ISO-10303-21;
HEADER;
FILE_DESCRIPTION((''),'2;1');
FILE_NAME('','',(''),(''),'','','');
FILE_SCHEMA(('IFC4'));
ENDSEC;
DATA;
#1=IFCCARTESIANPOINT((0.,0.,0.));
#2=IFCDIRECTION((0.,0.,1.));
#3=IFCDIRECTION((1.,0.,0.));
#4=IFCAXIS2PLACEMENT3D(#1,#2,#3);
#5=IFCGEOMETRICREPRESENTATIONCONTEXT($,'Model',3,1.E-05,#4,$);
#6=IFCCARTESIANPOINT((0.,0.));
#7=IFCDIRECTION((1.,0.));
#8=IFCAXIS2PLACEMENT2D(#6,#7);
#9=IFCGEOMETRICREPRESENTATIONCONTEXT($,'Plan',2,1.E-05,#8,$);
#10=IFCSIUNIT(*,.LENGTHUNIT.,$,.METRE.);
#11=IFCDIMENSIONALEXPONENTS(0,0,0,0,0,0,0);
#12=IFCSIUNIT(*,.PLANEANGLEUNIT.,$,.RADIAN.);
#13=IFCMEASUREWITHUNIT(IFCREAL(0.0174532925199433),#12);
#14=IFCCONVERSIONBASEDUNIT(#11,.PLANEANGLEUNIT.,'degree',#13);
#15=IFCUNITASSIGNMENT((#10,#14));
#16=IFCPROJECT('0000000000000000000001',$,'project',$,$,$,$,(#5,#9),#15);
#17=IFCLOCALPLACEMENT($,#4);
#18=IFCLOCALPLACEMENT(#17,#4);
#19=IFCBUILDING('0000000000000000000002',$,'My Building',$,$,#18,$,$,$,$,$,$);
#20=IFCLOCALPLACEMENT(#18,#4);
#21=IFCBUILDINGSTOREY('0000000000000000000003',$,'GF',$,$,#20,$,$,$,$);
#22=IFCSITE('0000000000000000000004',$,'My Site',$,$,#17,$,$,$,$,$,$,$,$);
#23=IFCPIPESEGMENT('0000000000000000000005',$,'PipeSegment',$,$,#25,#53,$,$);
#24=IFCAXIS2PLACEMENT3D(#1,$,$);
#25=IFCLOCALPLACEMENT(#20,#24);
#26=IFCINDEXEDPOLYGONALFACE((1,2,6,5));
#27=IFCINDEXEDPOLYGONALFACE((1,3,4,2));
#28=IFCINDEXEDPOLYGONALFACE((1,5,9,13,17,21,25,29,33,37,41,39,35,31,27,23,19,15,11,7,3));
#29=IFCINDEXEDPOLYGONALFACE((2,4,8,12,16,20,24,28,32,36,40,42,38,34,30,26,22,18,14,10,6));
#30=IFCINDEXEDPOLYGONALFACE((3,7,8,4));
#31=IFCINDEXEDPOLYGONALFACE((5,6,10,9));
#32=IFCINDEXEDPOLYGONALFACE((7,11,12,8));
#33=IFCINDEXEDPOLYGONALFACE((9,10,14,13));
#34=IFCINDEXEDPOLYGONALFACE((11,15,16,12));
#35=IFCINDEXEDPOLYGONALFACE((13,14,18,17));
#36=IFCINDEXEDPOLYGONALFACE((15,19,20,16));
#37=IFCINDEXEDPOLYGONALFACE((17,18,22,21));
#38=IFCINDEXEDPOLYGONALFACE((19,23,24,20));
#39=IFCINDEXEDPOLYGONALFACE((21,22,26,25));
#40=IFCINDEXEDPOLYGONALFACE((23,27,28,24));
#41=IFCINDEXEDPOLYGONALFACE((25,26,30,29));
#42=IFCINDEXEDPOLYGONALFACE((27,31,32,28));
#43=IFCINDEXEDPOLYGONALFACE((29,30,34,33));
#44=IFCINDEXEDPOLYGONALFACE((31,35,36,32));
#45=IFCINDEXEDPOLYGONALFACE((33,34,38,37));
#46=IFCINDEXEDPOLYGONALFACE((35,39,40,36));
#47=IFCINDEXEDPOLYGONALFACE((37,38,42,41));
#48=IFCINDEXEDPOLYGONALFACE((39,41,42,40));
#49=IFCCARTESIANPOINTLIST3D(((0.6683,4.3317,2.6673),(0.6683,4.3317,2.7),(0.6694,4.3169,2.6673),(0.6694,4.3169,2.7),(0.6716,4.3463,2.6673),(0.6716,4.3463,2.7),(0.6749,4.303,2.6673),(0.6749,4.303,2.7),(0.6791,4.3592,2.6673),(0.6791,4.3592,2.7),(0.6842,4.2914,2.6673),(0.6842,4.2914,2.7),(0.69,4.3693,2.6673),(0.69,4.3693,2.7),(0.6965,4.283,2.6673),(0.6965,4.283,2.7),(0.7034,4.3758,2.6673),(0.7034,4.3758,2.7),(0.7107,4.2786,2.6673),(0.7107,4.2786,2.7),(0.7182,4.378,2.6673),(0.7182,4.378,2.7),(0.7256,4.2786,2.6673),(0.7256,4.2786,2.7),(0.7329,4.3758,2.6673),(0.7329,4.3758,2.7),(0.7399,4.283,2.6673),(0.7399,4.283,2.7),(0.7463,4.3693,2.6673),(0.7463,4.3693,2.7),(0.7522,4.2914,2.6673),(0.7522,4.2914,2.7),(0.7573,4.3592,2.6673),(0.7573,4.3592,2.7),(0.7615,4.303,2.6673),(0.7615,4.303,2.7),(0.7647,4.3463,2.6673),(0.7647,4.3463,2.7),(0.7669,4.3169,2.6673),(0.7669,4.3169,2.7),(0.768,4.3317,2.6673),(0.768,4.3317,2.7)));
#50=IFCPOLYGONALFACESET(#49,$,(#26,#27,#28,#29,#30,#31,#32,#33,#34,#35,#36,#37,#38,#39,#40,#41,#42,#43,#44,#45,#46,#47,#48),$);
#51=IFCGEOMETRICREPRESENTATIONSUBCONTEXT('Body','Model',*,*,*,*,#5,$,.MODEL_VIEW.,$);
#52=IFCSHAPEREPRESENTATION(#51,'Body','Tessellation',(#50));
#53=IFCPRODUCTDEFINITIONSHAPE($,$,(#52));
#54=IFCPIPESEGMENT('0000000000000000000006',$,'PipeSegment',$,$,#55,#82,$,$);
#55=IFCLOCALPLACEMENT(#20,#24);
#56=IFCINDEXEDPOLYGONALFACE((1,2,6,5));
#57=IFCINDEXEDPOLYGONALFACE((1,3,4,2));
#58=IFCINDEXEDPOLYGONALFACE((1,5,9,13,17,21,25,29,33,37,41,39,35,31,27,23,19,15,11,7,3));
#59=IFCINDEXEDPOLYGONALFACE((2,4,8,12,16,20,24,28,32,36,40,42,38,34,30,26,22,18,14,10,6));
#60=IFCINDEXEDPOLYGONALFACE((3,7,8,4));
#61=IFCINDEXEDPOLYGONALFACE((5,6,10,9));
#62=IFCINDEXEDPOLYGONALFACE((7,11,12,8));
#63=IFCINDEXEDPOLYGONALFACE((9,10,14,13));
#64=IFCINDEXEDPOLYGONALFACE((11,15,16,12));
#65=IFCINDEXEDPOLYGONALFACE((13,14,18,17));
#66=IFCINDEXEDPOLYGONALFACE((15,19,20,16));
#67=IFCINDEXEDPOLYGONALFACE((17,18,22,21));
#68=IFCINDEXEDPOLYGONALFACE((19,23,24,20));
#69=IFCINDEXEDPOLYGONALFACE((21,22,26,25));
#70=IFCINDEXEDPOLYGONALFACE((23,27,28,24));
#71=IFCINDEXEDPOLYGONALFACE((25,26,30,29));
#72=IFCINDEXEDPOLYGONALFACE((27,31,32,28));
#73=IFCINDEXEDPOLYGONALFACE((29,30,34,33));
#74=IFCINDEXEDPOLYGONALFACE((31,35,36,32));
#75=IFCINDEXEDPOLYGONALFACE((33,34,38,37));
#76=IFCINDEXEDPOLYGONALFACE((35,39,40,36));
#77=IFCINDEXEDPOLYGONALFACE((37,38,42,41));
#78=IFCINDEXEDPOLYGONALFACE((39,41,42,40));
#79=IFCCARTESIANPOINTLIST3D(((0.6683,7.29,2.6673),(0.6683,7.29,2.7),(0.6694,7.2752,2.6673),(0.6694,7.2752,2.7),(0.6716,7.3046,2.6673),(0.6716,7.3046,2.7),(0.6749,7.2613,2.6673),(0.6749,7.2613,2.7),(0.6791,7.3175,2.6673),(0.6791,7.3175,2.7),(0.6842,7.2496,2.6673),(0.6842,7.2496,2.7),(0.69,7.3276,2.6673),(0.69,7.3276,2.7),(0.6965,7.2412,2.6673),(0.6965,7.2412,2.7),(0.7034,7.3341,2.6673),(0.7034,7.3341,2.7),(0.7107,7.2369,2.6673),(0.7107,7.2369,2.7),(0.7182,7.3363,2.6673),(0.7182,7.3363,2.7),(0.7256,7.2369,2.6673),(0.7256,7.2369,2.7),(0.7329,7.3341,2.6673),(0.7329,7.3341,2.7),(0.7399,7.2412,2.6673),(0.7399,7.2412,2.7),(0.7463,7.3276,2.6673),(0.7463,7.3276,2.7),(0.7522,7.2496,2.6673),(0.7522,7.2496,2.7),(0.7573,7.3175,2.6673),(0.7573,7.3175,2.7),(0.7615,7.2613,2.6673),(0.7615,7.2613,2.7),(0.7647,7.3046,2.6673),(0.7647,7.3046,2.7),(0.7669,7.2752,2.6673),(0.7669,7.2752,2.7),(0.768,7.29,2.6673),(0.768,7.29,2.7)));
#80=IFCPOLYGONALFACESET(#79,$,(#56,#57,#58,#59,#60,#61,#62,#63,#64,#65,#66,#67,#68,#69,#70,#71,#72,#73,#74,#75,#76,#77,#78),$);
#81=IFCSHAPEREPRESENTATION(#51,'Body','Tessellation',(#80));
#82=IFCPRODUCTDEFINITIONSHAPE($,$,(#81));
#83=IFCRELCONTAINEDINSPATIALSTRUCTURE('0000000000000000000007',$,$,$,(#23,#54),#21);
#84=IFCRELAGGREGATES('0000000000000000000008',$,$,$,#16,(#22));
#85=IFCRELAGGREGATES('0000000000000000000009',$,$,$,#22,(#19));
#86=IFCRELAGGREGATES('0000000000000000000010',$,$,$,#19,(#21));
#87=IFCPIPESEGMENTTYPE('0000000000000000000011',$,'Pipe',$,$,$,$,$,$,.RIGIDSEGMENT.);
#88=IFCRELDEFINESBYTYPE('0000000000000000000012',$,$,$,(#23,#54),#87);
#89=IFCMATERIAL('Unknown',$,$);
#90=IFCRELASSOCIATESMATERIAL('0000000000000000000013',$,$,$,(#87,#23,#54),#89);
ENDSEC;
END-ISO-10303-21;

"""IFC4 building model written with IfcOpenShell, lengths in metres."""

from ifc_helpers import new_model, entity, si_unit, converted_unit, frame, origin_with_axes, origin_2d_with_axis, place, context, subcontext, project, spatial, circle, extrude, material, material_profile, profile_set, profile_usage, type_object, element, save


model = new_model("IFC4")

# Units and contexts
model_context = context("Model", 3, precision=1e-05, world=origin_with_axes())
plan_context = context("Plan", 2, precision=1e-05, world=origin_2d_with_axis())
body_context_1 = subcontext(model_context, "Body", "Model", "MODEL_VIEW")
ifc_project = project(units=[si_unit("LENGTHUNIT", "METRE"), converted_unit("PLANEANGLEUNIT", "degree", entity("IfcReal", 0.0174532925199433), si_unit("PLANEANGLEUNIT", "RADIAN"), dimensions=[0, 0, 0, 0, 0, 0, 0])], contexts=[model_context, plan_context])

# Site, building, storey
site_placement = place(None, origin_with_axes())
site = spatial("IfcSite", under=ifc_project, at=site_placement, Name="My Site")
building_placement = place(site_placement, origin_with_axes())
building = spatial("IfcBuilding", under=site, at=building_placement, Name="My Building")
storey_placement = place(building_placement, origin_with_axes())
storey = spatial("IfcBuildingStorey", under=building, at=storey_placement, Name="GF")

# Shared definitions
ifc_material = material(Name="Unknown")

# Pipe segments
ifc_material_profile = material_profile(ifc_material, circle(Radius=0.05))
ifc_profile_set = profile_set([ifc_material_profile])
pipe_segment_type = type_object("IfcPipeSegmentType", Name="Pipe", PredefinedType="RIGIDSEGMENT", material=ifc_profile_set)
ifc_profile_usage_1 = profile_usage(ifc_profile_set, cardinal=5)
pipe_segment_1_placement = place(storey_placement, frame((0.7182, 4.328, 2.7), z_axis=(0.0, 0.0, -1.0), x_axis=(0.0, 1.0, 0.0)))
element("IfcPipeSegment", 1, at=pipe_segment_1_placement, inside=storey, type_object=pipe_segment_type, material=ifc_profile_usage_1, Name="PipeSegment", context=body_context_1, shape_type="SweptSolid", body=[
    extrude(circle(Radius=0.05), origin_with_axes(), (0.0, 0.0, 1.0), 0.0328),
])
ifc_profile_usage_2 = profile_usage(ifc_profile_set, cardinal=5)
pipe_segment_2_placement = place(storey_placement, frame((0.7182, 7.2863, 2.7), z_axis=(0.0, 0.0, -1.0), x_axis=(0.0, 1.0, 0.0)))
element("IfcPipeSegment", 2, at=pipe_segment_2_placement, inside=storey, type_object=pipe_segment_type, material=ifc_profile_usage_2, Name="PipeSegment", context=body_context_1, shape_type="SweptSolid", body=[
    extrude(circle(Radius=0.05), origin_with_axes(), (0.0, 0.0, 1.0), 0.0328),
])

save(model, "model.ifc")
